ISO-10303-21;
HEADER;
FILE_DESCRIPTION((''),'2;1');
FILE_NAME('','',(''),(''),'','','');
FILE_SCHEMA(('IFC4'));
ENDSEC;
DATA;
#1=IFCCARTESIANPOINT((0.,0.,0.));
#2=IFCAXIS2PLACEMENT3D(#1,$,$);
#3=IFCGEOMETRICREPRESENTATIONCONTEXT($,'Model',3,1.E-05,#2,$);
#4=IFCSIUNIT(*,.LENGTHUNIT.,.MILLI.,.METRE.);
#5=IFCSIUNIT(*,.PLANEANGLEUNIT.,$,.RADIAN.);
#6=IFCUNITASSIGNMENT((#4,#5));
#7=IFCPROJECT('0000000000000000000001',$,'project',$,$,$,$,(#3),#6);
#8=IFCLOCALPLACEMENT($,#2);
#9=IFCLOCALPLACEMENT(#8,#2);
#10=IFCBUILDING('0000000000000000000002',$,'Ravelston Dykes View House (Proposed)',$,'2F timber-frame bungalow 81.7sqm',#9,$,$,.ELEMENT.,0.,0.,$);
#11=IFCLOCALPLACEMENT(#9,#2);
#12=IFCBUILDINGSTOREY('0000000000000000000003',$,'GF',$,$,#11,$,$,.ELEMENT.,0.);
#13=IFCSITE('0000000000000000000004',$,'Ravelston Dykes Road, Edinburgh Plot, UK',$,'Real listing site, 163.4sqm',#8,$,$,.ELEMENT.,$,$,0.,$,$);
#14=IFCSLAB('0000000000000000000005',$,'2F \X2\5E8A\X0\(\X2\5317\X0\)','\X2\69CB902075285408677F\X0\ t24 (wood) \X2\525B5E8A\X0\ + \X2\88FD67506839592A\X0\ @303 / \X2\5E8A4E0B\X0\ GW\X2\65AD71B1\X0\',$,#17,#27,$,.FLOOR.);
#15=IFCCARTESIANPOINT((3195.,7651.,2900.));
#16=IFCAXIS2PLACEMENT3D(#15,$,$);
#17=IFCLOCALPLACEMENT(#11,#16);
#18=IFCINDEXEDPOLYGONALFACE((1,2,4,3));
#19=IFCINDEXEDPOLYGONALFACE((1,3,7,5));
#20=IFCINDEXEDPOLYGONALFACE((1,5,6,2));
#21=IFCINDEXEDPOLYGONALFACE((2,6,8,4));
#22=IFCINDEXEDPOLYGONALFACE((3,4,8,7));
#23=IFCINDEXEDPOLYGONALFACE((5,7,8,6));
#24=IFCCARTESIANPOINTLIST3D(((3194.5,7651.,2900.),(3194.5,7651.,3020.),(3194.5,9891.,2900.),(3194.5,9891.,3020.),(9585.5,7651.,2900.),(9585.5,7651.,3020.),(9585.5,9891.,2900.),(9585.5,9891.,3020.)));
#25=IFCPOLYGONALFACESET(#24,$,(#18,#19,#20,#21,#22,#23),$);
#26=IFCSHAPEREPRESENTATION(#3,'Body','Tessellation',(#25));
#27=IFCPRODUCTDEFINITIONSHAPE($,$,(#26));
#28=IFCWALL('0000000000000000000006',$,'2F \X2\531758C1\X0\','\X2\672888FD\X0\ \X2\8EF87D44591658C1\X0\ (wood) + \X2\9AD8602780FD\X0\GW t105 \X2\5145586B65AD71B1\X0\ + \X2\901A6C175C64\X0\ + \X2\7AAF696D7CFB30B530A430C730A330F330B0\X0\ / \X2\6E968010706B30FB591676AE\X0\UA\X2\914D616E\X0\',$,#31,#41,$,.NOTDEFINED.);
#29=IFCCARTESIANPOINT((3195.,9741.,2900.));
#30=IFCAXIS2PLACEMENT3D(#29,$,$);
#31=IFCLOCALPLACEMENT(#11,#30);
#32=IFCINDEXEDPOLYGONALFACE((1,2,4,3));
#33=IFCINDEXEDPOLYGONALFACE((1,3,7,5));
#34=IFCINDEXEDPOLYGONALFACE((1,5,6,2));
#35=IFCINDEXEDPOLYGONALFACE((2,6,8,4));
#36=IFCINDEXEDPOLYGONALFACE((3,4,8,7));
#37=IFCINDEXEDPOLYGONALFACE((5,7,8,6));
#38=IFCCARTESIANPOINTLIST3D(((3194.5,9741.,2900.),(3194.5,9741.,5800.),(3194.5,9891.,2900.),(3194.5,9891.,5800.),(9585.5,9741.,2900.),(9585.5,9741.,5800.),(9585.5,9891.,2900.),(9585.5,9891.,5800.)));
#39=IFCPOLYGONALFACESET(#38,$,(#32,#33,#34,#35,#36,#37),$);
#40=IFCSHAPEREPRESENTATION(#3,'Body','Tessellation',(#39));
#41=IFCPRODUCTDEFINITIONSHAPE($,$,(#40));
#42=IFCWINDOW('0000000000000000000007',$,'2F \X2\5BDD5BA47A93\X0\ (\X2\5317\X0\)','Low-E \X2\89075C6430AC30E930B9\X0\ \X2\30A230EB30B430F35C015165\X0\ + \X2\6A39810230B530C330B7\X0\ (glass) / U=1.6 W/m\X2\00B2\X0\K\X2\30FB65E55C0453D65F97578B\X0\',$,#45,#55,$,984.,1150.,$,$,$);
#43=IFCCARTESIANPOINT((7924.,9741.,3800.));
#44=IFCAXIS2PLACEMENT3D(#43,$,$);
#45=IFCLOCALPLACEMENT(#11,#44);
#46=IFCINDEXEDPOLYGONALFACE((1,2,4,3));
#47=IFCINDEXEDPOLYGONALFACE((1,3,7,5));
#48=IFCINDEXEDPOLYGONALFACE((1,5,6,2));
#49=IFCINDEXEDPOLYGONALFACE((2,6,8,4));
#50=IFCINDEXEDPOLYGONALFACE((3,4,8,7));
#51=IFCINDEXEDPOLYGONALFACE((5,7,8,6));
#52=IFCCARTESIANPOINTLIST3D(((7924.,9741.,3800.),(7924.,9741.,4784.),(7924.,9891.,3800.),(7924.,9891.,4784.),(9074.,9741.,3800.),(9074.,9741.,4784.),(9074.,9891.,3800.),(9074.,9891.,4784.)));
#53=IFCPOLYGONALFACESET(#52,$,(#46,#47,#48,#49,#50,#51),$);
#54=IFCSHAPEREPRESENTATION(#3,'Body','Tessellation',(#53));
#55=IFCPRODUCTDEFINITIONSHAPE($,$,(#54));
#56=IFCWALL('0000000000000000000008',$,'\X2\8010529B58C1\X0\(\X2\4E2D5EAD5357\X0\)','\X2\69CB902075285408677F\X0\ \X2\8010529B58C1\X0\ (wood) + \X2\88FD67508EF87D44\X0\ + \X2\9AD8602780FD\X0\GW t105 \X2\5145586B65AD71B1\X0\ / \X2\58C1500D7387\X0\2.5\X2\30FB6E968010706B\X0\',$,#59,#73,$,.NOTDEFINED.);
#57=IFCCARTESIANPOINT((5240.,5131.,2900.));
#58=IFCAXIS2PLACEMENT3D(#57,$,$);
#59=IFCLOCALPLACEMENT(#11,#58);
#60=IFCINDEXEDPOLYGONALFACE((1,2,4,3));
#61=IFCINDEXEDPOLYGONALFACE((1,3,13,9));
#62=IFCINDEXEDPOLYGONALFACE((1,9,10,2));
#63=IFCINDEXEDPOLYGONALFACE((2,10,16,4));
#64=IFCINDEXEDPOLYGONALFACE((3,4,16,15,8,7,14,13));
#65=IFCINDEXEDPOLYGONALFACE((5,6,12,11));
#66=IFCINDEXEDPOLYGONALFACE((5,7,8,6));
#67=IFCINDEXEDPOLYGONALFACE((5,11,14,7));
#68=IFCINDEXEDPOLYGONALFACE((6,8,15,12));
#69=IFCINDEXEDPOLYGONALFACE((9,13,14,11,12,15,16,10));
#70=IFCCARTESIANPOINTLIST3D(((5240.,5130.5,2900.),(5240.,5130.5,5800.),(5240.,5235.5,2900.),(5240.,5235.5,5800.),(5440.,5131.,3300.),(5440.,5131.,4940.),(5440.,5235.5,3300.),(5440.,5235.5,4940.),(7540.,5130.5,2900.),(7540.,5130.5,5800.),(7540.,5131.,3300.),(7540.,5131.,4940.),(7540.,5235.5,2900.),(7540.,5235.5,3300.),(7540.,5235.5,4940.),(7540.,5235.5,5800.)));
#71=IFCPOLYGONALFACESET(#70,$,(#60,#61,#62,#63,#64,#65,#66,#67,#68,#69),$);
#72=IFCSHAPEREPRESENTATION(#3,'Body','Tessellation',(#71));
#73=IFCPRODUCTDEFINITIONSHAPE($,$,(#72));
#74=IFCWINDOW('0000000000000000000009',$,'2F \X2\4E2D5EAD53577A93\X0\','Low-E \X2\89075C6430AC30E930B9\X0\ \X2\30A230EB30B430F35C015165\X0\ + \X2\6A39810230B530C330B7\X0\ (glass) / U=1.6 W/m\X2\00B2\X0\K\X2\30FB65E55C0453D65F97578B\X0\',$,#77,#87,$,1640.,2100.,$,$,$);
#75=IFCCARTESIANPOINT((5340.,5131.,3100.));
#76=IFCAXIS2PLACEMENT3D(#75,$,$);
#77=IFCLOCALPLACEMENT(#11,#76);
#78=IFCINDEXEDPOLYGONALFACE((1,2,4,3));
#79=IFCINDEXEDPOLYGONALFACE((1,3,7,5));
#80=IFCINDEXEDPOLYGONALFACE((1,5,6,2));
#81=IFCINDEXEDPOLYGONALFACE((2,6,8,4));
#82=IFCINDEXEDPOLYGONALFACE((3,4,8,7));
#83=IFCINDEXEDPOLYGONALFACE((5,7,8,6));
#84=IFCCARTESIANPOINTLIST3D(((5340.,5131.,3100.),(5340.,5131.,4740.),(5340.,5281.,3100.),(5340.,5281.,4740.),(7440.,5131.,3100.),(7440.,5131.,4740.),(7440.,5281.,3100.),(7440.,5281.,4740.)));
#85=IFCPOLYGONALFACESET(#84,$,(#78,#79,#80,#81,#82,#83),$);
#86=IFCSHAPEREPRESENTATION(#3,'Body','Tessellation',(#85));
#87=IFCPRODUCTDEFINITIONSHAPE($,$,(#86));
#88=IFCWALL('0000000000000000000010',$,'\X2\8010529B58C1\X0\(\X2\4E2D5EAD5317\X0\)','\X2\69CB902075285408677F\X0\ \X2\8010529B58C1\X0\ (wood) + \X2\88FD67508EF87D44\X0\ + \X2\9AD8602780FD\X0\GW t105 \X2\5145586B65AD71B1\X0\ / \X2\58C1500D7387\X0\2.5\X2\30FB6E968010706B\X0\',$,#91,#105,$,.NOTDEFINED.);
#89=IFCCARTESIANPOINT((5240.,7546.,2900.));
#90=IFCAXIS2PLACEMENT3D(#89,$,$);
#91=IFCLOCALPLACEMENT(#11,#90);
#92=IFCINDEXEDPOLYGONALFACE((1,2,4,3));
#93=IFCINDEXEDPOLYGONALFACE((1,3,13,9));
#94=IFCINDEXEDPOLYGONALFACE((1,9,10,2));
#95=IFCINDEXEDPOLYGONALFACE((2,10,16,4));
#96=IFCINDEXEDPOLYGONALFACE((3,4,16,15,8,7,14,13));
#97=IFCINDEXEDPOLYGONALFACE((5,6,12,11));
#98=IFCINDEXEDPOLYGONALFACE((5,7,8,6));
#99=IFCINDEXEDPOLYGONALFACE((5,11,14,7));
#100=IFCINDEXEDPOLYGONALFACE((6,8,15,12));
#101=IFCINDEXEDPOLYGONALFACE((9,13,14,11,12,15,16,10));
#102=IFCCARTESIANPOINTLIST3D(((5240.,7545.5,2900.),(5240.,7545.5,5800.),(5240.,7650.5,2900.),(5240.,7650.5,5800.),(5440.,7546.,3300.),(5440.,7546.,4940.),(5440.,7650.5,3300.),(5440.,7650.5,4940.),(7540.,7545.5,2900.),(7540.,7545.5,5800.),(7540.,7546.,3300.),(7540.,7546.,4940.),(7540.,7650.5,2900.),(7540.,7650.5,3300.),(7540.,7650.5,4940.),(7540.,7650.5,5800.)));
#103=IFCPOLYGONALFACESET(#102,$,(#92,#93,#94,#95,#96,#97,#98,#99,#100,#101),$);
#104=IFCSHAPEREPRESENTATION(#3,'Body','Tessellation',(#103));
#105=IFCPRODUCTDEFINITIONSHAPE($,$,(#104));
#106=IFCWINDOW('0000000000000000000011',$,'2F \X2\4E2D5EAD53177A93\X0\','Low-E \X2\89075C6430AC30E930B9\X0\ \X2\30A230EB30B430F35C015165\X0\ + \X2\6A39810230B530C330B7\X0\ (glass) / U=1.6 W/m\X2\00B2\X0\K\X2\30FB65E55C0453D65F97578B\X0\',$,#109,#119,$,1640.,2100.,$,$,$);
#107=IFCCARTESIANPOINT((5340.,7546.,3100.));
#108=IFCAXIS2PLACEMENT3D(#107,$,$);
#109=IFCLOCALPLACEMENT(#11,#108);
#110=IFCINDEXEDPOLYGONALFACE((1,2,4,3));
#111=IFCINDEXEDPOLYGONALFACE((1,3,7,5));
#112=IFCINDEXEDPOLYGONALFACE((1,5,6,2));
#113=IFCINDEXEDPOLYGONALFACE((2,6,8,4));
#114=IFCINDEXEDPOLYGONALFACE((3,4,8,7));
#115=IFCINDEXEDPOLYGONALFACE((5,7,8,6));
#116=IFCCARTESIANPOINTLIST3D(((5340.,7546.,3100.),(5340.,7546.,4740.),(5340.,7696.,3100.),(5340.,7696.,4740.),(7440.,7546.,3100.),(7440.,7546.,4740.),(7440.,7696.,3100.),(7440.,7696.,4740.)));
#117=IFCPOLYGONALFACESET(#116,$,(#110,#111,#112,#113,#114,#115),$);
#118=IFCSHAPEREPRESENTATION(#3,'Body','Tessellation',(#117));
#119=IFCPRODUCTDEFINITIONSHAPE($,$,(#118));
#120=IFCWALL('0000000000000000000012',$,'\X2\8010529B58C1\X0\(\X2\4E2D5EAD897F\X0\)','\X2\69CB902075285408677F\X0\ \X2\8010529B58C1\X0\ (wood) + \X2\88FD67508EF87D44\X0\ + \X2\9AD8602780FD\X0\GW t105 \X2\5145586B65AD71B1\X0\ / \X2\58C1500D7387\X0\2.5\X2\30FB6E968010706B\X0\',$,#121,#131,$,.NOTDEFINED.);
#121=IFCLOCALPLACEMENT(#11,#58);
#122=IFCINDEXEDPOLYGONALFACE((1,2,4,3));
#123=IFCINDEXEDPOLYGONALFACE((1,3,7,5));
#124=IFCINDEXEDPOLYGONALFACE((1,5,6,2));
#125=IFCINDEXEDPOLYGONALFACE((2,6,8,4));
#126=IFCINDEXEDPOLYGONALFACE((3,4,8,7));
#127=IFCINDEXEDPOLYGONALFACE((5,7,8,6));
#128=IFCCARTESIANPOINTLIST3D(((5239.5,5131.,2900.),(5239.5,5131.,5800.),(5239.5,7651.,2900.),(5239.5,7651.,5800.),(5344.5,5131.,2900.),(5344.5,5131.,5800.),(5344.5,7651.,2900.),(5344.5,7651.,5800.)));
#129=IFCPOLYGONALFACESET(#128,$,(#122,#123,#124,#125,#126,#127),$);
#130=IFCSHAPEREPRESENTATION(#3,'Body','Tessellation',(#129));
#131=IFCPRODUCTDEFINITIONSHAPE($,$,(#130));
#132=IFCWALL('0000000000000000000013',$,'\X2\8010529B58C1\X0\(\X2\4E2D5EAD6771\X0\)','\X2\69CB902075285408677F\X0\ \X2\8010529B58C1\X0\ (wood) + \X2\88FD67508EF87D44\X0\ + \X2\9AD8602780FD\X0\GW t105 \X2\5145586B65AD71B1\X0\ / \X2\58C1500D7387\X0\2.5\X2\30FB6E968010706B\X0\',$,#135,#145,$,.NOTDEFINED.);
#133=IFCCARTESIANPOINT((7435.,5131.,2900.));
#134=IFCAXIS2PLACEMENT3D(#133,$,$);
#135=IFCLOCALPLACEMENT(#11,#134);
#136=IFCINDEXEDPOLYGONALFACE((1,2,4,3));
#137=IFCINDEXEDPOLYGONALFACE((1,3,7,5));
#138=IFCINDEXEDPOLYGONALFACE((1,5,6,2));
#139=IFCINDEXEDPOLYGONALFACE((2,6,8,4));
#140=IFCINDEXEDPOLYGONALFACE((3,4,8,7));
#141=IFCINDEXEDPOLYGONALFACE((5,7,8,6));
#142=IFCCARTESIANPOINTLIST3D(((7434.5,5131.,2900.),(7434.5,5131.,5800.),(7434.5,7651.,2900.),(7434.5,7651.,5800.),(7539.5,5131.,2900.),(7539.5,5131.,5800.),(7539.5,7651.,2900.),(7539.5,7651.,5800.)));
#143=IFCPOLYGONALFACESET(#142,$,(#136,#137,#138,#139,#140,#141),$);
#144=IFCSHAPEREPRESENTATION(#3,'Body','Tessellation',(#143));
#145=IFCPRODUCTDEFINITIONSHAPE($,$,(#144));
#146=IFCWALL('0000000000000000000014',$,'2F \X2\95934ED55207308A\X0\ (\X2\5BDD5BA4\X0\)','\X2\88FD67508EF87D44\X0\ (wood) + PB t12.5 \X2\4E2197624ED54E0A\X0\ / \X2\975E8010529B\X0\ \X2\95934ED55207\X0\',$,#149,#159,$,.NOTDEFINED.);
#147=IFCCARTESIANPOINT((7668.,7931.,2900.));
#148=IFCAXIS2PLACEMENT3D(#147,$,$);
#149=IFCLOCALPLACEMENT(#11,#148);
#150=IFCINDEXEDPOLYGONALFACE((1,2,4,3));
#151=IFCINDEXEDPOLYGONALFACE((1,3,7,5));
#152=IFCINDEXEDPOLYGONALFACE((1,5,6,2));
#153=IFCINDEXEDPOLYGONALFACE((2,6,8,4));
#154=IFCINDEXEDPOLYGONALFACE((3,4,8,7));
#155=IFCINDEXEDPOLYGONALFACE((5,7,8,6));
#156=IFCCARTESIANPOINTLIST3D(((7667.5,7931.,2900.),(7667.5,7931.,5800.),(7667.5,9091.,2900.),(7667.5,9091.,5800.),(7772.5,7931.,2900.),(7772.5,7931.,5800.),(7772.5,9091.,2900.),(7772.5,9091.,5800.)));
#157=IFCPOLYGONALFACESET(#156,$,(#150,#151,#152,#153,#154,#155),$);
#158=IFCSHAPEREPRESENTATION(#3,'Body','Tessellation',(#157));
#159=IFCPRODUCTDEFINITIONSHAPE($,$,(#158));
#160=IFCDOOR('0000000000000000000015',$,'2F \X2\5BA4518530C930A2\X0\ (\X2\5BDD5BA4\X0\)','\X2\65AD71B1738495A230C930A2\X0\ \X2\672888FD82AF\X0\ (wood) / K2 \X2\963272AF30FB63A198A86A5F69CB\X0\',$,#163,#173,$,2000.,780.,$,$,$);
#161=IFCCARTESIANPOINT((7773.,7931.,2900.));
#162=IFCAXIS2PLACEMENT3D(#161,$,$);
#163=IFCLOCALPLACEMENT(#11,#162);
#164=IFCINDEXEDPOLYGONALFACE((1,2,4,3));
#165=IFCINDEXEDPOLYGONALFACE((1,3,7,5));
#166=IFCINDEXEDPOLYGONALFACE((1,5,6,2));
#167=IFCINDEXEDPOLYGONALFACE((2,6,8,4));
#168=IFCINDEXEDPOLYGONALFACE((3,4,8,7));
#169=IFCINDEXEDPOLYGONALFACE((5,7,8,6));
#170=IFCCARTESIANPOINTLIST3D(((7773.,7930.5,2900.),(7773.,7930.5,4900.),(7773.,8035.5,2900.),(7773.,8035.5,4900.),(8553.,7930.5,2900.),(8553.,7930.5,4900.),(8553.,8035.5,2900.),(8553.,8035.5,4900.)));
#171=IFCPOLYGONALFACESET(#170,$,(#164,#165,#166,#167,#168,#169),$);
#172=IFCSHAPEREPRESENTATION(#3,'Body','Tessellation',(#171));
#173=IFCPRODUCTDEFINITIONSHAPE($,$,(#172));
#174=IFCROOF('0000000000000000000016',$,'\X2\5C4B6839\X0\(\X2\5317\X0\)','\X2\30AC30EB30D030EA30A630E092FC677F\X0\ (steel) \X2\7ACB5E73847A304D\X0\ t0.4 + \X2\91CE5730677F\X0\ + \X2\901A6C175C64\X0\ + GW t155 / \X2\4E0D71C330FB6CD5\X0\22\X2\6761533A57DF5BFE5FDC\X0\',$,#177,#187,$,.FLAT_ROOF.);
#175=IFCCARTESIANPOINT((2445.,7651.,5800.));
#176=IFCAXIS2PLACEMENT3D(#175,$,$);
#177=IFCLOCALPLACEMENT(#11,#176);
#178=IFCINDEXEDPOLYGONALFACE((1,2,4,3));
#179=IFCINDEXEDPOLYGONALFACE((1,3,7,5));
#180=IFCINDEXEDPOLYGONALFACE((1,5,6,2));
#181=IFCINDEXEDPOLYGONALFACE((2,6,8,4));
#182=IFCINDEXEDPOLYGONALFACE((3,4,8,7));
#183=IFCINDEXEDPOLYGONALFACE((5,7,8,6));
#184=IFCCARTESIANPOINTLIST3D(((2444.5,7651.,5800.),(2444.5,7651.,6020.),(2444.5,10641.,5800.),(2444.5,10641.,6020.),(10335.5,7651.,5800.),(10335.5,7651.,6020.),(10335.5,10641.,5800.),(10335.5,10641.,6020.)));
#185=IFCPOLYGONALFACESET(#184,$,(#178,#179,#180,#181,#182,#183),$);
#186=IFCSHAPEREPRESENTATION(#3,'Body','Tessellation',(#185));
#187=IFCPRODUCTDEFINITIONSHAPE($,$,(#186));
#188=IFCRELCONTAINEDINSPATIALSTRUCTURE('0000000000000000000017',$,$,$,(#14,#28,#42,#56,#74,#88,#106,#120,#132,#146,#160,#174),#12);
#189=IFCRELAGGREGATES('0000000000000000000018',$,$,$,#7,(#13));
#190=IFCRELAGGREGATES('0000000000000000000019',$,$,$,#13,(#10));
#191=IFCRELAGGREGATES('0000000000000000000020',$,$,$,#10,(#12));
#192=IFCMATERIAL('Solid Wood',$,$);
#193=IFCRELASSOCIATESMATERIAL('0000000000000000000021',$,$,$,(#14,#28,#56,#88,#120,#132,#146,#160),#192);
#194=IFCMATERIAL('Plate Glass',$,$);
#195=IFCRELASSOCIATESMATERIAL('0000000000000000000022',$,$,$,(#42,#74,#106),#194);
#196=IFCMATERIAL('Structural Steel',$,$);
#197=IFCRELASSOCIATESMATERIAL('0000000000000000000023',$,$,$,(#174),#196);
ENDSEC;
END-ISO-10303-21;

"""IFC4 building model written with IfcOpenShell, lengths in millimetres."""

from ifc_helpers import new_model, si_unit, frame, frame_2d, origin, place, context, project, spatial, rectangle, extrude, material, element, fill, save


model = new_model("IFC4")

# Units and contexts
model_context = context("Model", 3, precision=1e-05, world=origin())
ifc_project = project(units=[si_unit("LENGTHUNIT", "METRE", prefix="MILLI"), si_unit("PLANEANGLEUNIT", "RADIAN")], contexts=[model_context])

# Site, building, storey
site_placement = place(None, origin())
site = spatial("IfcSite", under=ifc_project, at=site_placement, Name="Ravelston Dykes Road, Edinburgh Plot, UK", ObjectType="Real listing site, 163.4sqm", CompositionType="ELEMENT", RefElevation=0.0)
building_placement = place(site_placement, origin())
building = spatial("IfcBuilding", under=site, at=building_placement, Name="Ravelston Dykes View House (Proposed)", ObjectType="2F timber-frame bungalow 81.7sqm", CompositionType="ELEMENT", ElevationOfRefHeight=0.0, ElevationOfTerrain=0.0)
storey_placement = place(building_placement, origin())
storey = spatial("IfcBuildingStorey", under=building, at=storey_placement, Name="GF", CompositionType="ELEMENT", Elevation=0.0)

# Slab
ifc_material_1 = material(Name="Solid Wood")
slab_placement = place(storey_placement, frame((3195.0, 7651.0, 2900.0)))
element("IfcSlab", 1, at=slab_placement, inside=storey, material=ifc_material_1, Name="2F 床(北)", Description="構造用合板 t24 (wood) 剛床 + 製材根太 @303 / 床下 GW断熱", PredefinedType="FLOOR", context=model_context, shape_type="SweptSolid", body=[
    extrude(rectangle(XDim=6391.0, YDim=2240.0, at=frame_2d((3195.0, 1120.0))), frame((3195.0, 7651.0, 2900.0)), (0.0, 0.0, 1.0), 120.0),
])

# Walls, openings, windows
wall_1_placement = place(storey_placement, frame((3195.0, 9741.0, 2900.0)))
wall_1 = element("IfcWall", 2, at=wall_1_placement, inside=storey, material=ifc_material_1, Name="2F 北壁", Description="木製 軸組外壁 (wood) + 高性能GW t105 充填断熱 + 通気層 + 窯業系サイディング / 準耐火・外皮UA配慮", PredefinedType="NOTDEFINED", context=model_context, shape_type="SweptSolid", body=[
    extrude(rectangle(XDim=6391.0, YDim=150.0, at=frame_2d((3195.0, 75.0))), frame((3195.0, 9741.0, 2900.0)), (0.0, 0.0, 1.0), 2900.0),
])
opening_1_placement = place(storey_placement, frame((7924.0, 9741.0, 3800.0)))
opening_1 = element("IfcOpeningElement", 3, at=opening_1_placement, cuts=wall_1, PredefinedType="NOTDEFINED", context=model_context, shape_type="SweptSolid", body=[
    extrude(rectangle(XDim=1150.0, YDim=150.0, at=frame_2d((575.0, 75.0))), frame((7924.0, 9741.0, 3800.0)), (0.0, 0.0, 1.0), 984.0),
])
ifc_material_2 = material(Name="Plate Glass")
window_1_placement = place(storey_placement, frame((7924.0, 9741.0, 3800.0)))
window_1 = element("IfcWindow", 4, at=window_1_placement, inside=storey, material=ifc_material_2, Name="2F 寝室窓 (北)", Description="Low-E 複層ガラス アルゴン封入 + 樹脂サッシ (glass) / U=1.6 W/m²K・日射取得型", OverallHeight=984.0, OverallWidth=1150.0, context=model_context, shape_type="SweptSolid", body=[
    extrude(rectangle(XDim=1150.0, YDim=150.0, at=frame_2d((575.0, 75.0))), frame((7924.0, 9741.0, 3800.0)), (0.0, 0.0, 1.0), 984.0),
])
fill(opening_1, window_1)
wall_2_placement = place(storey_placement, frame((5240.0, 5131.0, 2900.0)))
wall_2 = element("IfcWall", 5, at=wall_2_placement, inside=storey, material=ifc_material_1, Name="耐力壁(中庭南)", Description="構造用合板 耐力壁 (wood) + 製材軸組 + 高性能GW t105 充填断熱 / 壁倍率2.5・準耐火", PredefinedType="NOTDEFINED", context=model_context, shape_type="SweptSolid", body=[
    extrude(rectangle(XDim=2300.0, YDim=105.0, at=frame_2d((1150.0, 52.0))), frame((5240.0, 5131.0, 2900.0)), (0.0, 0.0, 1.0), 2900.0),
])
opening_2_placement = place(storey_placement, frame((5340.0, 5131.0, 3100.0)))
opening_2 = element("IfcOpeningElement", 6, at=opening_2_placement, cuts=wall_2, PredefinedType="NOTDEFINED", context=model_context, shape_type="SweptSolid", body=[
    extrude(rectangle(XDim=2100.0, YDim=150.0, at=frame_2d((1050.0, 75.0))), frame((5340.0, 5131.0, 3100.0)), (0.0, 0.0, 1.0), 1640.0),
])
window_2_placement = place(storey_placement, frame((5340.0, 5131.0, 3100.0)))
window_2 = element("IfcWindow", 7, at=window_2_placement, inside=storey, material=ifc_material_2, Name="2F 中庭南窓", Description="Low-E 複層ガラス アルゴン封入 + 樹脂サッシ (glass) / U=1.6 W/m²K・日射取得型", OverallHeight=1640.0, OverallWidth=2100.0, context=model_context, shape_type="SweptSolid", body=[
    extrude(rectangle(XDim=2100.0, YDim=150.0, at=frame_2d((1050.0, 75.0))), frame((5340.0, 5131.0, 3100.0)), (0.0, 0.0, 1.0), 1640.0),
])
fill(opening_2, window_2)
wall_3_placement = place(storey_placement, frame((5240.0, 7546.0, 2900.0)))
wall_3 = element("IfcWall", 8, at=wall_3_placement, inside=storey, material=ifc_material_1, Name="耐力壁(中庭北)", Description="構造用合板 耐力壁 (wood) + 製材軸組 + 高性能GW t105 充填断熱 / 壁倍率2.5・準耐火", PredefinedType="NOTDEFINED", context=model_context, shape_type="SweptSolid", body=[
    extrude(rectangle(XDim=2300.0, YDim=105.0, at=frame_2d((1150.0, 52.0))), frame((5240.0, 7546.0, 2900.0)), (0.0, 0.0, 1.0), 2900.0),
])
opening_3_placement = place(storey_placement, frame((5340.0, 7546.0, 3100.0)))
opening_3 = element("IfcOpeningElement", 9, at=opening_3_placement, cuts=wall_3, PredefinedType="NOTDEFINED", context=model_context, shape_type="SweptSolid", body=[
    extrude(rectangle(XDim=2100.0, YDim=150.0, at=frame_2d((1050.0, 75.0))), frame((5340.0, 7546.0, 3100.0)), (0.0, 0.0, 1.0), 1640.0),
])
window_3_placement = place(storey_placement, frame((5340.0, 7546.0, 3100.0)))
window_3 = element("IfcWindow", 10, at=window_3_placement, inside=storey, material=ifc_material_2, Name="2F 中庭北窓", Description="Low-E 複層ガラス アルゴン封入 + 樹脂サッシ (glass) / U=1.6 W/m²K・日射取得型", OverallHeight=1640.0, OverallWidth=2100.0, context=model_context, shape_type="SweptSolid", body=[
    extrude(rectangle(XDim=2100.0, YDim=150.0, at=frame_2d((1050.0, 75.0))), frame((5340.0, 7546.0, 3100.0)), (0.0, 0.0, 1.0), 1640.0),
])
fill(opening_3, window_3)

# Walls
wall_4_placement = place(storey_placement, frame((5240.0, 5131.0, 2900.0)))
element("IfcWall", 11, at=wall_4_placement, inside=storey, material=ifc_material_1, Name="耐力壁(中庭西)", Description="構造用合板 耐力壁 (wood) + 製材軸組 + 高性能GW t105 充填断熱 / 壁倍率2.5・準耐火", PredefinedType="NOTDEFINED", context=model_context, shape_type="SweptSolid", body=[
    extrude(rectangle(XDim=105.0, YDim=2520.0, at=frame_2d((52.0, 1260.0))), frame((5240.0, 5131.0, 2900.0)), (0.0, 0.0, 1.0), 2900.0),
])
wall_5_placement = place(storey_placement, frame((7435.0, 5131.0, 2900.0)))
element("IfcWall", 12, at=wall_5_placement, inside=storey, material=ifc_material_1, Name="耐力壁(中庭東)", Description="構造用合板 耐力壁 (wood) + 製材軸組 + 高性能GW t105 充填断熱 / 壁倍率2.5・準耐火", PredefinedType="NOTDEFINED", context=model_context, shape_type="SweptSolid", body=[
    extrude(rectangle(XDim=105.0, YDim=2520.0, at=frame_2d((52.0, 1260.0))), frame((7435.0, 5131.0, 2900.0)), (0.0, 0.0, 1.0), 2900.0),
])
wall_6_placement = place(storey_placement, frame((7668.0, 7931.0, 2900.0)))
element("IfcWall", 13, at=wall_6_placement, inside=storey, material=ifc_material_1, Name="2F 間仕切り (寝室)", Description="製材軸組 (wood) + PB t12.5 両面仕上 / 非耐力 間仕切", PredefinedType="NOTDEFINED", context=model_context, shape_type="SweptSolid", body=[
    extrude(rectangle(XDim=105.0, YDim=1160.0, at=frame_2d((52.0, 580.0))), frame((7668.0, 7931.0, 2900.0)), (0.0, 0.0, 1.0), 2900.0),
])

# Door
door_placement = place(storey_placement, frame((7773.0, 7931.0, 2900.0)))
element("IfcDoor", 14, at=door_placement, inside=storey, material=ifc_material_1, Name="2F 室内ドア (寝室)", Description="断熱玄関ドア 木製芯 (wood) / K2 防犯・採風機構", OverallHeight=2000.0, OverallWidth=780.0, context=model_context, shape_type="SweptSolid", body=[
    extrude(rectangle(XDim=780.0, YDim=105.0, at=frame_2d((390.0, 52.0))), frame((7773.0, 7931.0, 2900.0)), (0.0, 0.0, 1.0), 2000.0),
])

# Roof
ifc_material_3 = material(Name="Structural Steel")
for number, where, name in (
    (15, (2445.0, 7651.0, 5800.0), "屋根(北)"),
):
    element("IfcRoof", number, at=place(storey_placement, frame(where)), inside=storey, material=ifc_material_3, Name=name, Description="ガルバリウム鋼板 (steel) 立平葺き t0.4 + 野地板 + 通気層 + GW t155 / 不燃・法22条区域対応", PredefinedType="FLAT_ROOF", context=model_context, shape_type="SweptSolid", body=[
        extrude(rectangle(XDim=7891.0, YDim=2990.0, at=frame_2d((3945.0, 1495.0))), frame((2445.0, 7651.0, 5800.0)), (0.0, 0.0, 1.0), 220.0),
    ])

save(model, "model.ifc")
